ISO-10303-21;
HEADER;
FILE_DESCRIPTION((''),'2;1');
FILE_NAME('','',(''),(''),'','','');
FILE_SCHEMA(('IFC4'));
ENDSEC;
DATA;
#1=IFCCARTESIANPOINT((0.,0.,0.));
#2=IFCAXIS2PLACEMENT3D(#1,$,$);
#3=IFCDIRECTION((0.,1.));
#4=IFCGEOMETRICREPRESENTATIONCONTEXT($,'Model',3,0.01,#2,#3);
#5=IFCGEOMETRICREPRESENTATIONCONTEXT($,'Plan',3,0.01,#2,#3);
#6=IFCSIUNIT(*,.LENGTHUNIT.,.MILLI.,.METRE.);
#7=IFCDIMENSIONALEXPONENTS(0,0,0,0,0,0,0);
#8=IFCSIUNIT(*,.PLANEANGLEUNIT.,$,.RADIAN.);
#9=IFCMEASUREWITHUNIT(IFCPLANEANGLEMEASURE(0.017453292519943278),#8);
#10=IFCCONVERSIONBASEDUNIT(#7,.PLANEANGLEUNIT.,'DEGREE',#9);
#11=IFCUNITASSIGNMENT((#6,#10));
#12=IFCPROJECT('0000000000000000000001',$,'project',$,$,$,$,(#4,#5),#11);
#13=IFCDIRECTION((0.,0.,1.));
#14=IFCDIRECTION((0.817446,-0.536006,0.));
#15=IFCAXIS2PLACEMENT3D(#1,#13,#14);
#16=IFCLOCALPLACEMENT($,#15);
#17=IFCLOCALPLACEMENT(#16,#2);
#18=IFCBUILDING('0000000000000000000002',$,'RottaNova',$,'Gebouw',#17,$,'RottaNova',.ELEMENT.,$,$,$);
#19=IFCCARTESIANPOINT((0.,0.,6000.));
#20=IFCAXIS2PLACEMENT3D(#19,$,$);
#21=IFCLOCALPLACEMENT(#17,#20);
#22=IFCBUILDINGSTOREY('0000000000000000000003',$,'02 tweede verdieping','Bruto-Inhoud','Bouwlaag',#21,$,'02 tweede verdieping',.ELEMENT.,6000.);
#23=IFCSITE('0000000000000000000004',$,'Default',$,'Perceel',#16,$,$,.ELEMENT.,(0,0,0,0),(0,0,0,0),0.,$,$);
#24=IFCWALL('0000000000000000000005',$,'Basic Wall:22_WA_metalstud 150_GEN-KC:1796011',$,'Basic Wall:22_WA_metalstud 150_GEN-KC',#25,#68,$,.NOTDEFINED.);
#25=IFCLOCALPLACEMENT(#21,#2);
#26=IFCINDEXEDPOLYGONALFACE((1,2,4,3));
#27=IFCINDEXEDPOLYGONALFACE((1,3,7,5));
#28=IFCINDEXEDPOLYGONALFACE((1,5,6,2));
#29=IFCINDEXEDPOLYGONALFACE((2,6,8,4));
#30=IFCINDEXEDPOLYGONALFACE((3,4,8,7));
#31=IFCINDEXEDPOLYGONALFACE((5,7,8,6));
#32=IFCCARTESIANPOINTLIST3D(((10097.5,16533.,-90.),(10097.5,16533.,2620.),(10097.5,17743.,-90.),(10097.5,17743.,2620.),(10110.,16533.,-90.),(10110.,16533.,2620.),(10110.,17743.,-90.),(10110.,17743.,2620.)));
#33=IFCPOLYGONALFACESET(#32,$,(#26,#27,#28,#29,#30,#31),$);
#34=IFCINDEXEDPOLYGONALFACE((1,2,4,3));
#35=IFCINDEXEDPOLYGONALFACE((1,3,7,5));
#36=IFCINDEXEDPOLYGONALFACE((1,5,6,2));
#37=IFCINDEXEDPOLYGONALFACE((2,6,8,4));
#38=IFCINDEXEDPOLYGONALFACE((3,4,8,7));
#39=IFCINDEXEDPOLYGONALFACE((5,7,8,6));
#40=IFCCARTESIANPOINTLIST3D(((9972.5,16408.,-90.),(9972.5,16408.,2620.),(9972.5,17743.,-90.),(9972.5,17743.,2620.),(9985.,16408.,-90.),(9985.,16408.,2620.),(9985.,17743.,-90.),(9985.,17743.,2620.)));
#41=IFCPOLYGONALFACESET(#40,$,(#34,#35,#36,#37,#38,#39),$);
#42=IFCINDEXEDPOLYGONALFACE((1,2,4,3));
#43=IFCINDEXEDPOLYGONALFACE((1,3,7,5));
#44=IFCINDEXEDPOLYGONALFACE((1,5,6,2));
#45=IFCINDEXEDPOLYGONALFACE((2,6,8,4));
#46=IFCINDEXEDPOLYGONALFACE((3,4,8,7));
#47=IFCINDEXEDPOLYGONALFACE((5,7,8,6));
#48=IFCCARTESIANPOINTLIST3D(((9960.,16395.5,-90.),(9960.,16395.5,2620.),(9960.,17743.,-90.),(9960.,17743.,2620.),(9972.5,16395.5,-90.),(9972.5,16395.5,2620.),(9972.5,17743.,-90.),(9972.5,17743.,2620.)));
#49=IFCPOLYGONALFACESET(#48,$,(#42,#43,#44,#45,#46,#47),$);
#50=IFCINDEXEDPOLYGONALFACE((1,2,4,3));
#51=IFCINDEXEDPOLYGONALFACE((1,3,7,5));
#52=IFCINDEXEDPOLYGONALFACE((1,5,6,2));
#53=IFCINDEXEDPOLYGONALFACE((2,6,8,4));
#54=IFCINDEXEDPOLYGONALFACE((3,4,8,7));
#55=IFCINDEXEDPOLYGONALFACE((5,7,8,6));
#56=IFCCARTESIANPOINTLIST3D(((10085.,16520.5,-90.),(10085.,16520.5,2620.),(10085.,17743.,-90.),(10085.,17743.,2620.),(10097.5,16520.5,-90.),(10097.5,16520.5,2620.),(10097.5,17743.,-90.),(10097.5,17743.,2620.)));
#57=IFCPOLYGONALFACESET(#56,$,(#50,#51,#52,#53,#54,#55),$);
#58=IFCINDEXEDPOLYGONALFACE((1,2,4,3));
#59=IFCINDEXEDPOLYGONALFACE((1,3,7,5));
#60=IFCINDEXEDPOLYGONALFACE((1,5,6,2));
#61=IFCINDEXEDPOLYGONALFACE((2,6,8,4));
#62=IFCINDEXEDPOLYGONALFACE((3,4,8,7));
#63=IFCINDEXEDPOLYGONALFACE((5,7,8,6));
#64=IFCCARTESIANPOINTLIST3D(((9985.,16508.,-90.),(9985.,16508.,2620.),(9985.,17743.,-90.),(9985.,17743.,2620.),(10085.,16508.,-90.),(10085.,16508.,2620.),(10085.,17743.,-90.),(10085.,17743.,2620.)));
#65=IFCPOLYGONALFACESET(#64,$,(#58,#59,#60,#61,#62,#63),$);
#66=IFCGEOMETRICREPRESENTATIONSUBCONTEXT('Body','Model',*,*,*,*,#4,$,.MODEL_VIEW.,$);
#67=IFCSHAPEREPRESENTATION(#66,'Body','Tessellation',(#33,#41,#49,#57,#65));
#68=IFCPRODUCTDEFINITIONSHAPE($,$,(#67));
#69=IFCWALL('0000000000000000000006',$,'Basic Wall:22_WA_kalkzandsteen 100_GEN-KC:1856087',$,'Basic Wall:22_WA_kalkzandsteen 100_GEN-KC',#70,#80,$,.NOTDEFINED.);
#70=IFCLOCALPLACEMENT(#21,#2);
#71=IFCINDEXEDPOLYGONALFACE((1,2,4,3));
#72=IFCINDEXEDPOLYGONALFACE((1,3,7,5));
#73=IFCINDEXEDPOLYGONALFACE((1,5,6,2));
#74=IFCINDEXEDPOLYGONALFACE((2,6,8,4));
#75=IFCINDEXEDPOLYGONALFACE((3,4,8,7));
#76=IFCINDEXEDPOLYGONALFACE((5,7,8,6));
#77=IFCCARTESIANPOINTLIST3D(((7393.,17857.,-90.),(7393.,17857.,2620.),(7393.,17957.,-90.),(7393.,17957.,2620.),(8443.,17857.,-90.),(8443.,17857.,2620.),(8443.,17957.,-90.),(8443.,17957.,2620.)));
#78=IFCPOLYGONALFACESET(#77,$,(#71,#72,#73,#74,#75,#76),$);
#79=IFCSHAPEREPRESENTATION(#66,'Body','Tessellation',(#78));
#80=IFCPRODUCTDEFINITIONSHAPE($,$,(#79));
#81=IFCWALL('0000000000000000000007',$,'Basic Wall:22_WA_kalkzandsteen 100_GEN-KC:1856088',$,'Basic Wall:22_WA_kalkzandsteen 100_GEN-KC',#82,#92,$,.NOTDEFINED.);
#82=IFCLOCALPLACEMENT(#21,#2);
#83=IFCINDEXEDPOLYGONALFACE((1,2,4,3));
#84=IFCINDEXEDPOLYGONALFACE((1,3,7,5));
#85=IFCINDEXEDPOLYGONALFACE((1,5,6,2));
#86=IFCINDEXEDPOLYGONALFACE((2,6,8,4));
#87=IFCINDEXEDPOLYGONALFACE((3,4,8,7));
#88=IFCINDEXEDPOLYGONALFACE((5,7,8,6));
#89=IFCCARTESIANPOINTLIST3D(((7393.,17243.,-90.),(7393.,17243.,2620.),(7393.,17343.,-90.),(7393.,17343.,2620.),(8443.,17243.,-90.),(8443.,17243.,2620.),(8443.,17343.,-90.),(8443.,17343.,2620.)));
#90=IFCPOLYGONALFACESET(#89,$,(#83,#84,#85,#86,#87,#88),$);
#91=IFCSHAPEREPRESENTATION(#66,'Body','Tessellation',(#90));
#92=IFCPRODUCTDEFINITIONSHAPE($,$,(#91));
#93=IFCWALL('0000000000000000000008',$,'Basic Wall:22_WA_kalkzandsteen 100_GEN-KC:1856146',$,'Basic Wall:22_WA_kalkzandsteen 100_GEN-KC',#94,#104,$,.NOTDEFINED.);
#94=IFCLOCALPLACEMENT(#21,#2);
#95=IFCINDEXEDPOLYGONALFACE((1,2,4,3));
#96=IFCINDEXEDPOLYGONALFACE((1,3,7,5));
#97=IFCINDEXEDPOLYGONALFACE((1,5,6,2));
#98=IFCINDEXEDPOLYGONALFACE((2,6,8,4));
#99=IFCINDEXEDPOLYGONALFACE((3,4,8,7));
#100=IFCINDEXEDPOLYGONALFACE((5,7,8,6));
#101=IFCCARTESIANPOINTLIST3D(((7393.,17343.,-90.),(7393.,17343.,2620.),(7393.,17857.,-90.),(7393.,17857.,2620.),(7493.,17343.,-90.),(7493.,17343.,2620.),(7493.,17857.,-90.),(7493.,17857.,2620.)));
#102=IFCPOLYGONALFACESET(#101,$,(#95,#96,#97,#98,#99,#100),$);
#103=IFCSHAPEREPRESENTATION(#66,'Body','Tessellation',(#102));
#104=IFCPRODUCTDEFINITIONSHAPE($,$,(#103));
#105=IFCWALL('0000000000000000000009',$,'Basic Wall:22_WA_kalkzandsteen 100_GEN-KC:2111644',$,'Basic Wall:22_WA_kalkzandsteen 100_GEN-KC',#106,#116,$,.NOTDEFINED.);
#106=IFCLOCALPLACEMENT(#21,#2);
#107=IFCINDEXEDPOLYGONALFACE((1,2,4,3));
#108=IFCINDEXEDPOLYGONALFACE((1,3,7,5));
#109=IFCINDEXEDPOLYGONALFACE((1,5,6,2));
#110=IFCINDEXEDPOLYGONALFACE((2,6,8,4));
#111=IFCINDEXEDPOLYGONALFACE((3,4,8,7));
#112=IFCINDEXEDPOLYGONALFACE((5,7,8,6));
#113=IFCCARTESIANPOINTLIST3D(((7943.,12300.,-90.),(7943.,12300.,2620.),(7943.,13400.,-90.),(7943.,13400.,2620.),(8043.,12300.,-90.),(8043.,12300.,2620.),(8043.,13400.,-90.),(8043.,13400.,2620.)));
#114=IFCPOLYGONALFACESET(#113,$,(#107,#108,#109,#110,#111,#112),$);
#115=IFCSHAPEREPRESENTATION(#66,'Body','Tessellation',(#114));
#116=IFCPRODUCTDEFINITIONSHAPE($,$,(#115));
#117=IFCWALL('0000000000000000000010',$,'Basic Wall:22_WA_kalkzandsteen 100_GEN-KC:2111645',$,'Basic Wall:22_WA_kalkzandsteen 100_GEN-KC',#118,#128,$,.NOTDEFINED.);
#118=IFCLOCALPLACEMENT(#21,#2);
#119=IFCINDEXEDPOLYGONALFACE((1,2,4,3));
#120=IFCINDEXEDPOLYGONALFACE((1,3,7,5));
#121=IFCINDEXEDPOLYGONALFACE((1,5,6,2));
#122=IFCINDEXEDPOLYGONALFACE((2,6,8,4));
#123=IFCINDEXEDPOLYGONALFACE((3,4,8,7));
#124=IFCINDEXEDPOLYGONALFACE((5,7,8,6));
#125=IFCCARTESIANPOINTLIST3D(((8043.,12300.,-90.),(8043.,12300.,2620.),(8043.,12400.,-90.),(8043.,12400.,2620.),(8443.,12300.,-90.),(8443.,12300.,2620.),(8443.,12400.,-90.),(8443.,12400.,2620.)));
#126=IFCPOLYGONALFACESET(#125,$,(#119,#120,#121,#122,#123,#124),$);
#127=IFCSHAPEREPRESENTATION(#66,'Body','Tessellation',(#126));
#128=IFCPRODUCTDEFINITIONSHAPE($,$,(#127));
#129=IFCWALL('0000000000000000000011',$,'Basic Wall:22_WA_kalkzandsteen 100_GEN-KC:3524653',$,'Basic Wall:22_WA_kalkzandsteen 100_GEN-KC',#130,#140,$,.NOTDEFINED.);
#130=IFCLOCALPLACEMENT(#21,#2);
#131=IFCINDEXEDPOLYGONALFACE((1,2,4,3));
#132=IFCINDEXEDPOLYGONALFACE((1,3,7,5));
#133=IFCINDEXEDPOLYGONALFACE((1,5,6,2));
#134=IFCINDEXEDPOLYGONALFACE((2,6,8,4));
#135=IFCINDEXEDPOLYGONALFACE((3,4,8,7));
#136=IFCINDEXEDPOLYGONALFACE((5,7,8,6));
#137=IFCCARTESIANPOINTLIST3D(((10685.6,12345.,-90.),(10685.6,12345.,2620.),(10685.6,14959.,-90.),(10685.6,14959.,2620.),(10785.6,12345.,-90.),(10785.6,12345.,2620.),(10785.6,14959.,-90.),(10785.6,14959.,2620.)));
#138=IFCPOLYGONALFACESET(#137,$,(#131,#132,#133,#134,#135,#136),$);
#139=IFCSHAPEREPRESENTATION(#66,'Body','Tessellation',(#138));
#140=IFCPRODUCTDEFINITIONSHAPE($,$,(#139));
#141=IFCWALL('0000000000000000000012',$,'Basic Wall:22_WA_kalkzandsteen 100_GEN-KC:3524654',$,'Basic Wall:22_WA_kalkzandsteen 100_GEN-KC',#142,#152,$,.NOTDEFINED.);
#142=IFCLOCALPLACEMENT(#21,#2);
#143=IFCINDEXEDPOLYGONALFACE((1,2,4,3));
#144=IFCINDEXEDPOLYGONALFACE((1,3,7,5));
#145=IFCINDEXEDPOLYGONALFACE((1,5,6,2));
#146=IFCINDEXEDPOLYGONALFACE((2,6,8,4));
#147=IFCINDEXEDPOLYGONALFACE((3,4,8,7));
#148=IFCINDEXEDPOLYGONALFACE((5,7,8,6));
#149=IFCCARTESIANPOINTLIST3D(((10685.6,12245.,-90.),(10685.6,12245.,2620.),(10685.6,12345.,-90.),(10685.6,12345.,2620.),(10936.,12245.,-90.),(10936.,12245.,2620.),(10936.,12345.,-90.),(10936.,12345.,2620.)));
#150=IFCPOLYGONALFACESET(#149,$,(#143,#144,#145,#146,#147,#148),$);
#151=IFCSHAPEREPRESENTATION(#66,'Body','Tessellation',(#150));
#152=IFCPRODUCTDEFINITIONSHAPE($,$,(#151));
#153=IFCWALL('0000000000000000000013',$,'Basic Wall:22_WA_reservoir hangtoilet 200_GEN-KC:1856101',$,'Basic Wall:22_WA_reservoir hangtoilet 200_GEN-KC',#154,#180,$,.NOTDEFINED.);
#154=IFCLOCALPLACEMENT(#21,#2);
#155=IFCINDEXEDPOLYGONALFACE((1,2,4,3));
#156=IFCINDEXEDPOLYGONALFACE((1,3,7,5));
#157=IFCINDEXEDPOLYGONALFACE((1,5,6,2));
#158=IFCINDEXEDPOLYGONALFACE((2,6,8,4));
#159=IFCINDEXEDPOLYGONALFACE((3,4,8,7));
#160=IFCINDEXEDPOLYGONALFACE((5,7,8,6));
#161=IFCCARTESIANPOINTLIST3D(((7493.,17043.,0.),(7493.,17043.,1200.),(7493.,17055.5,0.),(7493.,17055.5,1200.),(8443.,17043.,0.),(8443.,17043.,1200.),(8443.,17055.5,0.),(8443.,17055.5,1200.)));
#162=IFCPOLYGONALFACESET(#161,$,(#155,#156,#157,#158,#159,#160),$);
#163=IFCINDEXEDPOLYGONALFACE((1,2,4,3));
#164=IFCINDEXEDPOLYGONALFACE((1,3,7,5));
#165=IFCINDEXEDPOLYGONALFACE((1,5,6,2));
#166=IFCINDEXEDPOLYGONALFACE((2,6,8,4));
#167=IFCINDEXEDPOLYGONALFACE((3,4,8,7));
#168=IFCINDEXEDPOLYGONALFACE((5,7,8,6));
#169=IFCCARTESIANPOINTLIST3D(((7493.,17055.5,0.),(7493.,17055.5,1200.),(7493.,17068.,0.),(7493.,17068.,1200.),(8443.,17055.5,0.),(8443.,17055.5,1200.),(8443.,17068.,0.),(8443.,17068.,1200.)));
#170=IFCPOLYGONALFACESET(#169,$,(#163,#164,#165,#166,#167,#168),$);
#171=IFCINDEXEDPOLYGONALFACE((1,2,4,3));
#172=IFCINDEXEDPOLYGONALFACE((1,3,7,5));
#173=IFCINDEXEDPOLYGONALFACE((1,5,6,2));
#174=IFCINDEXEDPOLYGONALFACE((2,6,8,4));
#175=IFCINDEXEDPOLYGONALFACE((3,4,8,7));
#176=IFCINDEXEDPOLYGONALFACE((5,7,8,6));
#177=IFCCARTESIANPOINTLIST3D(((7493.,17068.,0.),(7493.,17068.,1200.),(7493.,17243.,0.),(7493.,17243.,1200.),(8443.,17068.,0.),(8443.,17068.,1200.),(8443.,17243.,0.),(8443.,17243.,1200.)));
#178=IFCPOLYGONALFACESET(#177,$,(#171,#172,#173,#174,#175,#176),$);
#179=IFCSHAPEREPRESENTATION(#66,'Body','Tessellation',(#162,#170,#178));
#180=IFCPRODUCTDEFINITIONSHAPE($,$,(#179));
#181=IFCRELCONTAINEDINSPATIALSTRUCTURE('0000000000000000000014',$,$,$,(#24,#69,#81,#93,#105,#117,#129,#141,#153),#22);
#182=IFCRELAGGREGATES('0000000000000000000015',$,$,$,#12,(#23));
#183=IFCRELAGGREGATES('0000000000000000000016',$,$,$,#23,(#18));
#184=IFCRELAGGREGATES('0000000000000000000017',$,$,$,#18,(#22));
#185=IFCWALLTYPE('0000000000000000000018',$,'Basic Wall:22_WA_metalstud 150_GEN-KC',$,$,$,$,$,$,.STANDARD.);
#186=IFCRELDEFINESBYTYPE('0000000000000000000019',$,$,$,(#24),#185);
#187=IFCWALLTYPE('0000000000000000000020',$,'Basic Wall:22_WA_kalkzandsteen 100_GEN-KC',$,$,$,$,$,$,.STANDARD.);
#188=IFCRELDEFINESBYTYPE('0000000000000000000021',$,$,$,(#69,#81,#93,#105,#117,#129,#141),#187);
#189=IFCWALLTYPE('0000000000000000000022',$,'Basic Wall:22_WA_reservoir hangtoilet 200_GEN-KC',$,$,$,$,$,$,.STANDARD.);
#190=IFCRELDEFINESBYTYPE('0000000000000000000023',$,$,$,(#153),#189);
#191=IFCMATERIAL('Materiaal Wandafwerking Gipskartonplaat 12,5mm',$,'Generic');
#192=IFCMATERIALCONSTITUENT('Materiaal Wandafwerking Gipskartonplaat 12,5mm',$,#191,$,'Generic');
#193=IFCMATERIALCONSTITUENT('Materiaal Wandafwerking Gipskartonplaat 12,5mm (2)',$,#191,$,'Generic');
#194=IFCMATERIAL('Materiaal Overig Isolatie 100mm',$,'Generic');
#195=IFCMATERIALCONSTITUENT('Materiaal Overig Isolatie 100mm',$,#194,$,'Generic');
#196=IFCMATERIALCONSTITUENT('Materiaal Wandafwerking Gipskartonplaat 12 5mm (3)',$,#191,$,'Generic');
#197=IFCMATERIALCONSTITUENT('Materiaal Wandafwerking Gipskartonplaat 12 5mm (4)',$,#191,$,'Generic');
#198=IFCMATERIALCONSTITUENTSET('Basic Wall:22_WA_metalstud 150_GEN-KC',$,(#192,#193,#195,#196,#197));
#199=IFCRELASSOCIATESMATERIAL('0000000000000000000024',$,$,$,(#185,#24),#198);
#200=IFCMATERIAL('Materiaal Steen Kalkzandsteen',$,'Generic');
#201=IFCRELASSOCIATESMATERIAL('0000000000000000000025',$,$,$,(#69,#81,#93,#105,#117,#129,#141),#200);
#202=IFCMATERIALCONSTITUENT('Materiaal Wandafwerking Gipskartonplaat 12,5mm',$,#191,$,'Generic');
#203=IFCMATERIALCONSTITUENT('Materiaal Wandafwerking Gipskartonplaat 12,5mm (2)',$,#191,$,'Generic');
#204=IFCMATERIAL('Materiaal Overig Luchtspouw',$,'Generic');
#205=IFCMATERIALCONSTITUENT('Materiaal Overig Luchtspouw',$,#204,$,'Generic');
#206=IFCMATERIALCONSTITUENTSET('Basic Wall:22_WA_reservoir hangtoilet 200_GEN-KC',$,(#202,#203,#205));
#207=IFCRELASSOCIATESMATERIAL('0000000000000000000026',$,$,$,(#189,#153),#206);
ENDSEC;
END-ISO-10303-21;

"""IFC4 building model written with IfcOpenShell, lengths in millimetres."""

from ifc_helpers import new_model, entity, si_unit, converted_unit, direction, frame, origin, place, context, subcontext, project, spatial, indexed_curve, outline, extrude, material, constituent, constituent_set, type_object, element, save


model = new_model("IFC4")

# Units and contexts
model_context = context("Model", 3, precision=0.01, world=origin(), true_north=direction((0.0, 1.0)))
plan_context = context("Plan", 3, precision=0.01, world=origin(), true_north=direction((0.0, 1.0)))
body_context = subcontext(model_context, "Body", "Model", "MODEL_VIEW")
ifc_project = project(units=[si_unit("LENGTHUNIT", "METRE", prefix="MILLI"), converted_unit("PLANEANGLEUNIT", "DEGREE", entity("IfcPlaneAngleMeasure", 0.017453292519943278), si_unit("PLANEANGLEUNIT", "RADIAN"), dimensions=[0, 0, 0, 0, 0, 0, 0])], contexts=[model_context, plan_context])

# Site, building, storey
site_placement = place(None, frame((0.0, 0.0, 0.0), z_axis=(0.0, 0.0, 1.0), x_axis=(0.817446, -0.536006, 0.0)))
site = spatial("IfcSite", under=ifc_project, at=site_placement, Name="Default", ObjectType="Perceel", CompositionType="ELEMENT", RefLatitude=(0, 0, 0, 0), RefLongitude=(0, 0, 0, 0), RefElevation=0.0)
building_placement = place(site_placement, origin())
building = spatial("IfcBuilding", under=site, at=building_placement, Name="RottaNova", ObjectType="Gebouw", LongName="RottaNova", CompositionType="ELEMENT")
storey_placement = place(building_placement, frame((0.0, 0.0, 6000.0)))
storey = spatial("IfcBuildingStorey", under=building, at=storey_placement, Name="02 tweede verdieping", Description="Bruto-Inhoud", ObjectType="Bouwlaag", LongName="02 tweede verdieping", CompositionType="ELEMENT", Elevation=6000.0)

# Walls
ifc_material_1 = material(Name="Materiaal Steen Kalkzandsteen", Category="Generic")
ifc_material_2 = material(Name="Materiaal Wandafwerking Gipskartonplaat 12,5mm", Category="Generic")
ifc_constituent_1 = constituent(ifc_material_2, Name="Materiaal Wandafwerking Gipskartonplaat 12,5mm", Category="Generic")
ifc_constituent_2 = constituent(ifc_material_2, Name="Materiaal Wandafwerking Gipskartonplaat 12,5mm (2)", Category="Generic")
ifc_material_3 = material(Name="Materiaal Overig Isolatie 100mm", Category="Generic")
ifc_constituent_3 = constituent(ifc_material_3, Name="Materiaal Overig Isolatie 100mm", Category="Generic")
ifc_constituent_4 = constituent(ifc_material_2, Name="Materiaal Wandafwerking Gipskartonplaat 12 5mm (3)", Category="Generic")
ifc_constituent_5 = constituent(ifc_material_2, Name="Materiaal Wandafwerking Gipskartonplaat 12 5mm (4)", Category="Generic")
ifc_constituent_set_1 = constituent_set(constituents=[ifc_constituent_1, ifc_constituent_2, ifc_constituent_3, ifc_constituent_4, ifc_constituent_5], Name="Basic Wall:22_WA_metalstud 150_GEN-KC")
wall_type_1 = type_object("IfcWallType", Name="Basic Wall:22_WA_metalstud 150_GEN-KC", PredefinedType="STANDARD", material=ifc_constituent_set_1)
wall_1_placement = place(storey_placement, frame((10035.0, 16533.0, -90.0), z_axis=(0.0, 0.0, 1.0), x_axis=(0.0, 1.0, 0.0)))
element("IfcWall", 1, at=wall_1_placement, inside=storey, type_object=wall_type_1, material=ifc_constituent_set_1, Name="Basic Wall:22_WA_metalstud 150_GEN-KC:1796011", ObjectType="Basic Wall:22_WA_metalstud 150_GEN-KC", PredefinedType="NOTDEFINED", context=body_context, shape_type="SweptSolid", body=[
    extrude(outline(indexed_curve([(-6.3, -605.0), (6.2, -605.0), (6.3, 605.0), (-6.2, 605.0), (-6.3, -605.0)], self_intersect=False)), frame((605.0, -68.7, 0.0), z_axis=(0.0, 0.0, 1.0), x_axis=(0.0, 1.0, 0.0)), (0.0, 0.0, 1.0), 2710.0),
    extrude(outline(indexed_curve([(-667.5, -6.2), (667.5, -6.2), (667.5, 6.3), (-667.5, 6.3), (-667.5, -6.2)], self_intersect=False)), frame((542.5, 56.2, 0.0)), (0.0, 0.0, 1.0), 2710.0),
    extrude(outline(indexed_curve([(-6.3, -673.8), (6.2, -673.8), (6.3, 673.8), (-6.2, 673.8), (-6.3, -673.8)], self_intersect=False)), frame((536.3, 68.8, 0.0), z_axis=(0.0, 0.0, 1.0), x_axis=(0.0, -1.0, 0.0)), (0.0, 0.0, 1.0), 2710.0),
    extrude(outline(indexed_curve([(-611.3, -6.2), (611.3, -6.2), (611.3, 6.3), (-611.3, 6.3), (-611.3, -6.2)], self_intersect=False)), frame((598.8, -56.3, 0.0)), (0.0, 0.0, 1.0), 2710.0),
    extrude(outline(indexed_curve([(-617.5, -50.0), (617.5, -50.0), (617.5, 50.0), (-617.5, 50.0), (-617.5, -50.0)], self_intersect=False)), frame((592.5, 0.0, 0.0)), (0.0, 0.0, 1.0), 2710.0),
])
wall_type_2 = type_object("IfcWallType", Name="Basic Wall:22_WA_kalkzandsteen 100_GEN-KC", PredefinedType="STANDARD")
for number, where, name in (
    (2, (7393.0, 17907.0, -90.0), "Basic Wall:22_WA_kalkzandsteen 100_GEN-KC:1856087"),
    (3, (7393.0, 17293.0, -90.0), "Basic Wall:22_WA_kalkzandsteen 100_GEN-KC:1856088"),
):
    element("IfcWall", number, at=place(storey_placement, frame(where)), inside=storey, type_object=wall_type_2, material=ifc_material_1, Name=name, ObjectType="Basic Wall:22_WA_kalkzandsteen 100_GEN-KC", PredefinedType="NOTDEFINED", context=body_context, shape_type="SweptSolid", body=[
        extrude(outline(indexed_curve([(1050.0, 50.0), (0.0, 50.0), (0.0, -50.0), (1050.0, -50.0), (1050.0, 50.0)], self_intersect=False)), origin(), (0.0, 0.0, 1.0), 2710.0),
    ])
wall_2_placement = place(storey_placement, frame((7443.0, 17343.0, -90.0), z_axis=(0.0, 0.0, 1.0), x_axis=(0.0, 1.0, 0.0)))
element("IfcWall", 4, at=wall_2_placement, inside=storey, type_object=wall_type_2, material=ifc_material_1, Name="Basic Wall:22_WA_kalkzandsteen 100_GEN-KC:1856146", ObjectType="Basic Wall:22_WA_kalkzandsteen 100_GEN-KC", PredefinedType="NOTDEFINED", context=body_context, shape_type="SweptSolid", body=[
    extrude(outline(indexed_curve([(514.0, 50.0), (0.0, 50.0), (0.0, -50.0), (514.0, -50.0), (514.0, 50.0)], self_intersect=False)), origin(), (0.0, 0.0, 1.0), 2710.0),
])
wall_3_placement = place(storey_placement, frame((7993.0, 13400.0, -90.0), z_axis=(0.0, 0.0, 1.0), x_axis=(0.0, -1.0, 0.0)))
element("IfcWall", 5, at=wall_3_placement, inside=storey, type_object=wall_type_2, material=ifc_material_1, Name="Basic Wall:22_WA_kalkzandsteen 100_GEN-KC:2111644", ObjectType="Basic Wall:22_WA_kalkzandsteen 100_GEN-KC", PredefinedType="NOTDEFINED", context=body_context, shape_type="SweptSolid", body=[
    extrude(outline(indexed_curve([(1100.0, 50.0), (0.0, 50.0), (0.0, -50.0), (1100.0, -50.0), (1100.0, 50.0)], self_intersect=False)), origin(), (0.0, 0.0, 1.0), 2710.0),
])
wall_4_placement = place(storey_placement, frame((8043.0, 12350.0, -90.0)))
element("IfcWall", 6, at=wall_4_placement, inside=storey, type_object=wall_type_2, material=ifc_material_1, Name="Basic Wall:22_WA_kalkzandsteen 100_GEN-KC:2111645", ObjectType="Basic Wall:22_WA_kalkzandsteen 100_GEN-KC", PredefinedType="NOTDEFINED", context=body_context, shape_type="SweptSolid", body=[
    extrude(outline(indexed_curve([(400.0, 50.0), (0.0, 50.0), (0.0, -50.0), (400.0, -50.0), (400.0, 50.0)], self_intersect=False)), origin(), (0.0, 0.0, 1.0), 2710.0),
])
wall_5_placement = place(storey_placement, frame((10735.6, 14959.0, -90.0), z_axis=(0.0, 0.0, 1.0), x_axis=(0.0, -1.0, 0.0)))
element("IfcWall", 7, at=wall_5_placement, inside=storey, type_object=wall_type_2, material=ifc_material_1, Name="Basic Wall:22_WA_kalkzandsteen 100_GEN-KC:3524653", ObjectType="Basic Wall:22_WA_kalkzandsteen 100_GEN-KC", PredefinedType="NOTDEFINED", context=body_context, shape_type="SweptSolid", body=[
    extrude(outline(indexed_curve([(2614.0, 50.0), (0.0, 50.0), (0.0, -50.0), (2614.0, -50.0), (2614.0, 50.0)], self_intersect=False)), origin(), (0.0, 0.0, 1.0), 2710.0),
])
wall_6_placement = place(storey_placement, frame((10685.6, 12295.0, -90.0)))
element("IfcWall", 8, at=wall_6_placement, inside=storey, type_object=wall_type_2, material=ifc_material_1, Name="Basic Wall:22_WA_kalkzandsteen 100_GEN-KC:3524654", ObjectType="Basic Wall:22_WA_kalkzandsteen 100_GEN-KC", PredefinedType="NOTDEFINED", context=body_context, shape_type="SweptSolid", body=[
    extrude(outline(indexed_curve([(250.4, 50.0), (0.0, 50.0), (0.0, -50.0), (250.4, -50.0), (250.4, 50.0)], self_intersect=False)), origin(), (0.0, 0.0, 1.0), 2710.0),
])
ifc_constituent_6 = constituent(ifc_material_2, Name="Materiaal Wandafwerking Gipskartonplaat 12,5mm", Category="Generic")
ifc_constituent_7 = constituent(ifc_material_2, Name="Materiaal Wandafwerking Gipskartonplaat 12,5mm (2)", Category="Generic")
ifc_material_4 = material(Name="Materiaal Overig Luchtspouw", Category="Generic")
ifc_constituent_8 = constituent(ifc_material_4, Name="Materiaal Overig Luchtspouw", Category="Generic")
ifc_constituent_set_2 = constituent_set(constituents=[ifc_constituent_6, ifc_constituent_7, ifc_constituent_8], Name="Basic Wall:22_WA_reservoir hangtoilet 200_GEN-KC")
wall_type_3 = type_object("IfcWallType", Name="Basic Wall:22_WA_reservoir hangtoilet 200_GEN-KC", PredefinedType="STANDARD", material=ifc_constituent_set_2)
wall_7_placement = place(storey_placement, frame((7493.0, 17143.0, 0.0)))
element("IfcWall", 9, at=wall_7_placement, inside=storey, type_object=wall_type_3, material=ifc_constituent_set_2, Name="Basic Wall:22_WA_reservoir hangtoilet 200_GEN-KC:1856101", ObjectType="Basic Wall:22_WA_reservoir hangtoilet 200_GEN-KC", PredefinedType="NOTDEFINED", context=body_context, shape_type="SweptSolid", body=[
    extrude(outline(indexed_curve([(-6.2, -475.0), (6.3, -475.0), (6.2, 475.0), (-6.3, 475.0), (-6.2, -475.0)], self_intersect=False)), frame((475.0, -93.7, 0.0), z_axis=(0.0, 0.0, 1.0), x_axis=(0.0, 1.0, 0.0)), (0.0, 0.0, 1.0), 1200.0),
    extrude(outline(indexed_curve([(-475.0, -6.2), (475.0, -6.2), (475.0, 6.3), (-475.0, 6.3), (-475.0, -6.2)], self_intersect=False)), frame((475.0, -81.3, 0.0)), (0.0, 0.0, 1.0), 1200.0),
    extrude(outline(indexed_curve([(-87.5, -475.0), (87.5, -475.0), (87.5, 475.0), (-87.5, 475.0), (-87.5, -475.0)], self_intersect=False)), frame((475.0, 12.5, 0.0), z_axis=(0.0, 0.0, 1.0), x_axis=(0.0, -1.0, 0.0)), (0.0, 0.0, 1.0), 1200.0),
])

save(model, "model.ifc")
